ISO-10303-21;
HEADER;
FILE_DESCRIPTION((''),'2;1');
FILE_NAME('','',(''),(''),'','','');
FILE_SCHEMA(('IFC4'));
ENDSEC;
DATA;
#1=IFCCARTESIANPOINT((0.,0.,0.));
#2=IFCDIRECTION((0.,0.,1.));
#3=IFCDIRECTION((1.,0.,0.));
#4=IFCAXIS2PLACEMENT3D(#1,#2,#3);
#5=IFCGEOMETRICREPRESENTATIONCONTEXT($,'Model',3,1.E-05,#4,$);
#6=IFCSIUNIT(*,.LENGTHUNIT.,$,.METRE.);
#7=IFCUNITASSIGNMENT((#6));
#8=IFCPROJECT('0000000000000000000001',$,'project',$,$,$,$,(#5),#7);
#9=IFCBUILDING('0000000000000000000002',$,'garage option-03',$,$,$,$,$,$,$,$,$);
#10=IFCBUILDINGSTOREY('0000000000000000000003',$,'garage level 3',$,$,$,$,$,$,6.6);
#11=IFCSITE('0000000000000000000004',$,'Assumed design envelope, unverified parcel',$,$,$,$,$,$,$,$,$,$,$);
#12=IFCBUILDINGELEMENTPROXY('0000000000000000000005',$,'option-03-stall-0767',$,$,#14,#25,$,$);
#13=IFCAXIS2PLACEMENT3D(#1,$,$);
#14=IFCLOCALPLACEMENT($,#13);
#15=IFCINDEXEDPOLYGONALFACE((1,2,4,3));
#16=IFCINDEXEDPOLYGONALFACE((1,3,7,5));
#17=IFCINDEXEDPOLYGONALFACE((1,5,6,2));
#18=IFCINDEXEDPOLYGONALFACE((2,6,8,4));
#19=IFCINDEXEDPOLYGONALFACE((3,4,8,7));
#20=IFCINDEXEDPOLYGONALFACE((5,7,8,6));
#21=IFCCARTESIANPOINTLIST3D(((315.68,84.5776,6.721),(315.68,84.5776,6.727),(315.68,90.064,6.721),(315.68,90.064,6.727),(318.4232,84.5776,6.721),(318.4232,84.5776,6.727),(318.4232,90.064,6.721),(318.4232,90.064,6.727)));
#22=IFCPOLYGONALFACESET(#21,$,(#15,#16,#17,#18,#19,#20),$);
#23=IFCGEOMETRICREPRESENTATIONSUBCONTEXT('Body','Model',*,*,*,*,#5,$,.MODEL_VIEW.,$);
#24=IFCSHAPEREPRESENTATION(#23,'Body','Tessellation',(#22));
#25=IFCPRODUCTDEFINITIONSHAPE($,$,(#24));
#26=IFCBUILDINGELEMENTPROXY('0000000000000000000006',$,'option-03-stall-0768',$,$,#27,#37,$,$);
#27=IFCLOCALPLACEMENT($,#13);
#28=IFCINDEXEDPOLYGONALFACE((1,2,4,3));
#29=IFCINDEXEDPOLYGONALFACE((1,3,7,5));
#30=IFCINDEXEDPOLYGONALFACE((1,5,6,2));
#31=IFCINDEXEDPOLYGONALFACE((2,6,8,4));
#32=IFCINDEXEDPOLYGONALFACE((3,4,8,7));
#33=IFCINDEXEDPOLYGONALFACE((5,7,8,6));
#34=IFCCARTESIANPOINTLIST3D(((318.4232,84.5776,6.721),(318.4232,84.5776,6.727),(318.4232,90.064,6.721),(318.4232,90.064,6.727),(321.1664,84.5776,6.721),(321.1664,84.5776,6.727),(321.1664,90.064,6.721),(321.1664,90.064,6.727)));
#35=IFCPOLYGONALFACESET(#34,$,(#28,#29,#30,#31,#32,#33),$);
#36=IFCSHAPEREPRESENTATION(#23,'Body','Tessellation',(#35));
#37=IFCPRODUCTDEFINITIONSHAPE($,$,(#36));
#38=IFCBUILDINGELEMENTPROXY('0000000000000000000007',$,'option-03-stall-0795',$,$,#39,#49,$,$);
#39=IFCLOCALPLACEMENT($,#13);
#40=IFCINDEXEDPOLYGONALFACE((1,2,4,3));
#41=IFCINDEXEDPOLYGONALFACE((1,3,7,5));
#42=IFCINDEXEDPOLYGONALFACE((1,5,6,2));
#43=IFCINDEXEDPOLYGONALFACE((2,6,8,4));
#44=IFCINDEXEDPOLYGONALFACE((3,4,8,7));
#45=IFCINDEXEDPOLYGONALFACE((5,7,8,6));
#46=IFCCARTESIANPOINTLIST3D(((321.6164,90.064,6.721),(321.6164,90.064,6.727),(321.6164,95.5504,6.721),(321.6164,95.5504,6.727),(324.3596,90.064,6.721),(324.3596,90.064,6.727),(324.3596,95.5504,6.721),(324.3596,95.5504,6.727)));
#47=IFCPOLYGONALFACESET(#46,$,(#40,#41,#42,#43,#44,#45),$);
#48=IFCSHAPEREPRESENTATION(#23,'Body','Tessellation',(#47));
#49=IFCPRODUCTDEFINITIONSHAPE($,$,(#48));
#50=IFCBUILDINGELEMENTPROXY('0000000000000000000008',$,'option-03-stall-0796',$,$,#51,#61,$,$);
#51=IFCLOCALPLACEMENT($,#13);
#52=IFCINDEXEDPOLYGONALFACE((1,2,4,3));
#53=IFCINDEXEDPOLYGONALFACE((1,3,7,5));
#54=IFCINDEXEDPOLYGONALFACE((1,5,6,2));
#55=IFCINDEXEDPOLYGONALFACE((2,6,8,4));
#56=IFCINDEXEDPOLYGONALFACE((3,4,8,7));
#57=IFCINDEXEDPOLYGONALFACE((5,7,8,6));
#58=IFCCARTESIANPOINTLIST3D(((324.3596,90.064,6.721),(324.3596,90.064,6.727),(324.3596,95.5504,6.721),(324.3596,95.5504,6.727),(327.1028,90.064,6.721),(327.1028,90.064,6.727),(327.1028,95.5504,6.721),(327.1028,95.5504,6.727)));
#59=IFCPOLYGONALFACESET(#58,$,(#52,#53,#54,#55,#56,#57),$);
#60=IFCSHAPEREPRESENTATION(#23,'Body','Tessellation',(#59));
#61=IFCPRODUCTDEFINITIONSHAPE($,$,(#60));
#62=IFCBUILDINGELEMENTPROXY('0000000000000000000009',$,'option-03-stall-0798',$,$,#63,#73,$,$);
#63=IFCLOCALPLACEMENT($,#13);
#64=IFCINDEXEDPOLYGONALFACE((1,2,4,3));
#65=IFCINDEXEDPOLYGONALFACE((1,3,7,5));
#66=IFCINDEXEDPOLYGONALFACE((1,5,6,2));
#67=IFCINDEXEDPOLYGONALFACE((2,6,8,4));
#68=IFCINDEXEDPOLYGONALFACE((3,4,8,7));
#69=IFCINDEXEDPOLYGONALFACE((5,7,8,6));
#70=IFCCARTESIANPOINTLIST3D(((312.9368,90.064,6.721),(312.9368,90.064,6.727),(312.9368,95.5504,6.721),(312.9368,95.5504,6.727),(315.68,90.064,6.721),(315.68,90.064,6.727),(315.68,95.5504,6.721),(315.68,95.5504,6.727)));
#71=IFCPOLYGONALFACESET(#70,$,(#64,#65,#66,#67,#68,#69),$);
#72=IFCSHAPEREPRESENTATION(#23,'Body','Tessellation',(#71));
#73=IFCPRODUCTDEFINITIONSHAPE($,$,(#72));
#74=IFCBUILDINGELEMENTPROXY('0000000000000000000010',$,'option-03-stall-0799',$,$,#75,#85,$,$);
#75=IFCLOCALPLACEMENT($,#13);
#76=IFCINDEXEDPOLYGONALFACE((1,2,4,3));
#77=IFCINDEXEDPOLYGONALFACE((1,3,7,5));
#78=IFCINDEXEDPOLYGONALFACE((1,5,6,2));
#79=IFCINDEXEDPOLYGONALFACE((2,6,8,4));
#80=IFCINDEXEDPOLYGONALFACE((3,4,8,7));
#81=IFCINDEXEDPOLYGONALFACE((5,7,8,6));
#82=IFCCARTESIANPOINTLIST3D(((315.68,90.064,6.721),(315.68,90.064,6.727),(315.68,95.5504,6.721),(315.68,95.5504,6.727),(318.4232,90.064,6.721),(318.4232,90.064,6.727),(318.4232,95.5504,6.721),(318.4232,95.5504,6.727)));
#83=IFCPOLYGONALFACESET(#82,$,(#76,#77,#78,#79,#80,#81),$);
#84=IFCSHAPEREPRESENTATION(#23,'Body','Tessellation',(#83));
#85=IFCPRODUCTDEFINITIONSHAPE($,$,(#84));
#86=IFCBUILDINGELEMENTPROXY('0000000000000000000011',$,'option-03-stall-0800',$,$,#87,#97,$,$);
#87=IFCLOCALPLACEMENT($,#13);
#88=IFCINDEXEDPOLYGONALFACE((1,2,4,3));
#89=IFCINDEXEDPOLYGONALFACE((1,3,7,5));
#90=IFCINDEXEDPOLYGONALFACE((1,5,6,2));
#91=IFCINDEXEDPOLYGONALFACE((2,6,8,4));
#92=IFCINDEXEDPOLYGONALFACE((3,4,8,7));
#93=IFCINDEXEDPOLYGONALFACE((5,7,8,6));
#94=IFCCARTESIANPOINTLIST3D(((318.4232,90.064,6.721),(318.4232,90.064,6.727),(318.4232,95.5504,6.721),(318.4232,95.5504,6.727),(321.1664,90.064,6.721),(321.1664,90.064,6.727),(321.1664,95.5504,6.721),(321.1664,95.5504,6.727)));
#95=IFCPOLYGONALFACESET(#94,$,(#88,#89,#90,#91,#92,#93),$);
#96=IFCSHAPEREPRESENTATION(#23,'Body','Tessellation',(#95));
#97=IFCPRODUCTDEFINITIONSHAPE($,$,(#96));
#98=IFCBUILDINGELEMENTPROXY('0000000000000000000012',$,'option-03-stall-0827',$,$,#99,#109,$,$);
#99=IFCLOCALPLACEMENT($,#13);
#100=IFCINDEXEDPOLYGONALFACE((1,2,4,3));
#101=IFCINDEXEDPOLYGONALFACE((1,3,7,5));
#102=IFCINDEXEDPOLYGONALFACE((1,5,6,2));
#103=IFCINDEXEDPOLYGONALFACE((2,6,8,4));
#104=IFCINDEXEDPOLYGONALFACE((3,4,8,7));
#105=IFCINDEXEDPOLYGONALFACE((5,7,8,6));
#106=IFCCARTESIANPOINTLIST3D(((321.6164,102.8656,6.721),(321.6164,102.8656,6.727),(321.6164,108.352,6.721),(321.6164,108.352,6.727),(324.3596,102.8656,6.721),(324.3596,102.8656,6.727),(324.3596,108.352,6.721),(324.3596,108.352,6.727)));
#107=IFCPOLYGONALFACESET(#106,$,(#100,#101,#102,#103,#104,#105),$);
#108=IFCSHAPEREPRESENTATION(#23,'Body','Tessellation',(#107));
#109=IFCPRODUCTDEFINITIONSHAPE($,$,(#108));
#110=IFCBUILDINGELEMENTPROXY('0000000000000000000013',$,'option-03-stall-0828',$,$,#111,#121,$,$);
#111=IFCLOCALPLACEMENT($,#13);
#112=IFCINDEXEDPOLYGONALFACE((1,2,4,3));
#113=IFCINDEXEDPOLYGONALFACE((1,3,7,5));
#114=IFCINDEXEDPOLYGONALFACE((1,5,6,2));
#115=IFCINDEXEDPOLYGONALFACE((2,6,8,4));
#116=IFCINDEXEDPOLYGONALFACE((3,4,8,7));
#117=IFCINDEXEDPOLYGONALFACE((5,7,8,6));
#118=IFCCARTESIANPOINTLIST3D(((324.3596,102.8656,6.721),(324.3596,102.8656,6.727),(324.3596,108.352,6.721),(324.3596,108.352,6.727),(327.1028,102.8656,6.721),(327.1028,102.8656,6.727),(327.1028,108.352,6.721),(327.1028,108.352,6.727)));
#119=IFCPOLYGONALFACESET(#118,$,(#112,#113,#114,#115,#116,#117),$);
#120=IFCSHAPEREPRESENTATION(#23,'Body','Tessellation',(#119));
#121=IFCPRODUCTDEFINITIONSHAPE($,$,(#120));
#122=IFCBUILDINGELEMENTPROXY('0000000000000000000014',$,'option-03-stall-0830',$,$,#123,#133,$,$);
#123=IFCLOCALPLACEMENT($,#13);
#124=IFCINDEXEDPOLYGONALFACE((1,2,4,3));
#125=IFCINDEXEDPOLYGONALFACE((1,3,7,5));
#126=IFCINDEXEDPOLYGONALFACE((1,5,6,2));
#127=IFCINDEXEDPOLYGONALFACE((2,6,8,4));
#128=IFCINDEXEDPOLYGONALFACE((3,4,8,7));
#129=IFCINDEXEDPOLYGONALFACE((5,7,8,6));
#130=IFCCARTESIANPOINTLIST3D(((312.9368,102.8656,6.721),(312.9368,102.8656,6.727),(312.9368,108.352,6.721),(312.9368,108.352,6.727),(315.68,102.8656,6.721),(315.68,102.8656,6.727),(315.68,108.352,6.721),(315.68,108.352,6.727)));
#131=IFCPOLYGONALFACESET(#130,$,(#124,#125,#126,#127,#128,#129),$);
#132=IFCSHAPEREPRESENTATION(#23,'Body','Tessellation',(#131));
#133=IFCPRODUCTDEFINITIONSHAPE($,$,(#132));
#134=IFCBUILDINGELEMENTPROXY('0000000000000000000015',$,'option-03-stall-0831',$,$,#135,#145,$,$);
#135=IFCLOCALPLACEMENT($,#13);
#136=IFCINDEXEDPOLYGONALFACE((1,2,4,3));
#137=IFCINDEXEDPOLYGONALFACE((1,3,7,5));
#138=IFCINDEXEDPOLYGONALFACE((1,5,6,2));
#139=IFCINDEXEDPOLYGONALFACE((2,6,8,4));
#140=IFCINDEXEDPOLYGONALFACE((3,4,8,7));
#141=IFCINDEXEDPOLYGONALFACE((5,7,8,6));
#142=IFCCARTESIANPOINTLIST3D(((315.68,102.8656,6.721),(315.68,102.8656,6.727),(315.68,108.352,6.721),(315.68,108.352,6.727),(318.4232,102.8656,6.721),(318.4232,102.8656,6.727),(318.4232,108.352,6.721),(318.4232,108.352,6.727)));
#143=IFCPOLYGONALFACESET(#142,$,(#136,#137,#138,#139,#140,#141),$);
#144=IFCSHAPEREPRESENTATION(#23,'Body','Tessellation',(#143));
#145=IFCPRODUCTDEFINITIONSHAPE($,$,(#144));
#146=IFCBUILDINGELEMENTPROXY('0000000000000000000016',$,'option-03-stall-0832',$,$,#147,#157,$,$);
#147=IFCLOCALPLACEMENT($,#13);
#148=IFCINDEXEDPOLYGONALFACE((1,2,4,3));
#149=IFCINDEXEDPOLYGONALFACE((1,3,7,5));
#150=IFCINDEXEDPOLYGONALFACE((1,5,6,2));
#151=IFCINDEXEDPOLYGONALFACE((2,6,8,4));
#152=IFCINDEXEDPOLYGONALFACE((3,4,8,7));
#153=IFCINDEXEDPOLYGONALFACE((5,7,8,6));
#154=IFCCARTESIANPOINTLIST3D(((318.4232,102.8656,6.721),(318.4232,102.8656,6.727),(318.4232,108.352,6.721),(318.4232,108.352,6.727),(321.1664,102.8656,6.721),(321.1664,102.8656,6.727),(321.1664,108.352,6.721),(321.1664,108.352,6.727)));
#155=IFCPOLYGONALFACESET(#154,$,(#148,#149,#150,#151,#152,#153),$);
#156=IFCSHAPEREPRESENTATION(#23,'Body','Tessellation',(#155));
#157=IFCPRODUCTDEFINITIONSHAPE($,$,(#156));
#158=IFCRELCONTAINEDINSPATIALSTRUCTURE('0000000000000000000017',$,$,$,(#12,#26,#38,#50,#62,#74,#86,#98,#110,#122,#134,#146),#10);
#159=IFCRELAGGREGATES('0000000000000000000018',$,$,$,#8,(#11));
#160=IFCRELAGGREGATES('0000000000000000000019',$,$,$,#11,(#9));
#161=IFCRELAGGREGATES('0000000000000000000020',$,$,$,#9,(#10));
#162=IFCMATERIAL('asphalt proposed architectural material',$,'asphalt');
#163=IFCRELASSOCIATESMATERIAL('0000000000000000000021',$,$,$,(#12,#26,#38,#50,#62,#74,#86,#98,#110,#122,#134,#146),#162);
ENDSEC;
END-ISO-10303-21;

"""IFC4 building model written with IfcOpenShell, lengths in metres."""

from ifc_helpers import new_model, si_unit, frame, origin_with_axes, place, context, subcontext, project, spatial, rectangle, extrude, material, element, save


model = new_model("IFC4")

# Units and contexts
model_context = context("Model", 3, precision=1e-05, world=origin_with_axes())
body_context = subcontext(model_context, "Body", "Model", "MODEL_VIEW")
ifc_project = project(units=[si_unit("LENGTHUNIT", "METRE")], contexts=[model_context])

# Site, building, storey
site = spatial("IfcSite", under=ifc_project, Name="Assumed design envelope, unverified parcel")
building = spatial("IfcBuilding", under=site, Name="garage option-03")
storey = spatial("IfcBuildingStorey", under=building, Name="garage level 3", Elevation=6.6)

# Building element proxies
ifc_material_1 = material(Name="asphalt proposed architectural material", Category="asphalt")
for number, where, z_axis, x_axis, name in (
    (1, (317.0516, 87.3208, 6.721), (0.0, 0.0, 1.0), (1.0, 0.0, 0.0), "option-03-stall-0767"),
    (2, (319.7948, 87.3208, 6.721), (0.0, 0.0, 1.0), (1.0, 0.0, 0.0), "option-03-stall-0768"),
    (3, (322.988, 92.8072, 6.721), (0.0, 0.0, 1.0), (1.0, 0.0, 0.0), "option-03-stall-0795"),
    (4, (325.7312, 92.8072, 6.721), (0.0, 0.0, 1.0), (1.0, 0.0, 0.0), "option-03-stall-0796"),
    (5, (314.3084, 92.8072, 6.721), (0.0, 0.0, 1.0), (1.0, 0.0, 0.0), "option-03-stall-0798"),
    (6, (317.0516, 92.8072, 6.721), (0.0, 0.0, 1.0), (1.0, 0.0, 0.0), "option-03-stall-0799"),
    (7, (319.7948, 92.8072, 6.721), (0.0, 0.0, 1.0), (1.0, 0.0, 0.0), "option-03-stall-0800"),
    (8, (322.988, 105.6088, 6.721), (0.0, 0.0, 1.0), (1.0, 0.0, 0.0), "option-03-stall-0827"),
    (9, (325.7312, 105.6088, 6.721), (0.0, 0.0, 1.0), (1.0, 0.0, 0.0), "option-03-stall-0828"),
    (10, (314.3084, 105.6088, 6.721), (0.0, 0.0, 1.0), (1.0, 0.0, 0.0), "option-03-stall-0830"),
    (11, (317.0516, 105.6088, 6.721), (0.0, 0.0, 1.0), (1.0, 0.0, 0.0), "option-03-stall-0831"),
    (12, (319.7948, 105.6088, 6.721), (0.0, 0.0, 1.0), (1.0, 0.0, 0.0), "option-03-stall-0832"),
):
    element("IfcBuildingElementProxy", number, at=place(None, frame(where, z_axis=z_axis, x_axis=x_axis)), inside=storey, material=ifc_material_1, Name=name, context=body_context, shape_type="SweptSolid", body=[
        extrude(rectangle(XDim=2.7432, YDim=5.4864), origin_with_axes(), (0.0, 0.0, 1.0), 0.006),
    ])

save(model, "model.ifc")
